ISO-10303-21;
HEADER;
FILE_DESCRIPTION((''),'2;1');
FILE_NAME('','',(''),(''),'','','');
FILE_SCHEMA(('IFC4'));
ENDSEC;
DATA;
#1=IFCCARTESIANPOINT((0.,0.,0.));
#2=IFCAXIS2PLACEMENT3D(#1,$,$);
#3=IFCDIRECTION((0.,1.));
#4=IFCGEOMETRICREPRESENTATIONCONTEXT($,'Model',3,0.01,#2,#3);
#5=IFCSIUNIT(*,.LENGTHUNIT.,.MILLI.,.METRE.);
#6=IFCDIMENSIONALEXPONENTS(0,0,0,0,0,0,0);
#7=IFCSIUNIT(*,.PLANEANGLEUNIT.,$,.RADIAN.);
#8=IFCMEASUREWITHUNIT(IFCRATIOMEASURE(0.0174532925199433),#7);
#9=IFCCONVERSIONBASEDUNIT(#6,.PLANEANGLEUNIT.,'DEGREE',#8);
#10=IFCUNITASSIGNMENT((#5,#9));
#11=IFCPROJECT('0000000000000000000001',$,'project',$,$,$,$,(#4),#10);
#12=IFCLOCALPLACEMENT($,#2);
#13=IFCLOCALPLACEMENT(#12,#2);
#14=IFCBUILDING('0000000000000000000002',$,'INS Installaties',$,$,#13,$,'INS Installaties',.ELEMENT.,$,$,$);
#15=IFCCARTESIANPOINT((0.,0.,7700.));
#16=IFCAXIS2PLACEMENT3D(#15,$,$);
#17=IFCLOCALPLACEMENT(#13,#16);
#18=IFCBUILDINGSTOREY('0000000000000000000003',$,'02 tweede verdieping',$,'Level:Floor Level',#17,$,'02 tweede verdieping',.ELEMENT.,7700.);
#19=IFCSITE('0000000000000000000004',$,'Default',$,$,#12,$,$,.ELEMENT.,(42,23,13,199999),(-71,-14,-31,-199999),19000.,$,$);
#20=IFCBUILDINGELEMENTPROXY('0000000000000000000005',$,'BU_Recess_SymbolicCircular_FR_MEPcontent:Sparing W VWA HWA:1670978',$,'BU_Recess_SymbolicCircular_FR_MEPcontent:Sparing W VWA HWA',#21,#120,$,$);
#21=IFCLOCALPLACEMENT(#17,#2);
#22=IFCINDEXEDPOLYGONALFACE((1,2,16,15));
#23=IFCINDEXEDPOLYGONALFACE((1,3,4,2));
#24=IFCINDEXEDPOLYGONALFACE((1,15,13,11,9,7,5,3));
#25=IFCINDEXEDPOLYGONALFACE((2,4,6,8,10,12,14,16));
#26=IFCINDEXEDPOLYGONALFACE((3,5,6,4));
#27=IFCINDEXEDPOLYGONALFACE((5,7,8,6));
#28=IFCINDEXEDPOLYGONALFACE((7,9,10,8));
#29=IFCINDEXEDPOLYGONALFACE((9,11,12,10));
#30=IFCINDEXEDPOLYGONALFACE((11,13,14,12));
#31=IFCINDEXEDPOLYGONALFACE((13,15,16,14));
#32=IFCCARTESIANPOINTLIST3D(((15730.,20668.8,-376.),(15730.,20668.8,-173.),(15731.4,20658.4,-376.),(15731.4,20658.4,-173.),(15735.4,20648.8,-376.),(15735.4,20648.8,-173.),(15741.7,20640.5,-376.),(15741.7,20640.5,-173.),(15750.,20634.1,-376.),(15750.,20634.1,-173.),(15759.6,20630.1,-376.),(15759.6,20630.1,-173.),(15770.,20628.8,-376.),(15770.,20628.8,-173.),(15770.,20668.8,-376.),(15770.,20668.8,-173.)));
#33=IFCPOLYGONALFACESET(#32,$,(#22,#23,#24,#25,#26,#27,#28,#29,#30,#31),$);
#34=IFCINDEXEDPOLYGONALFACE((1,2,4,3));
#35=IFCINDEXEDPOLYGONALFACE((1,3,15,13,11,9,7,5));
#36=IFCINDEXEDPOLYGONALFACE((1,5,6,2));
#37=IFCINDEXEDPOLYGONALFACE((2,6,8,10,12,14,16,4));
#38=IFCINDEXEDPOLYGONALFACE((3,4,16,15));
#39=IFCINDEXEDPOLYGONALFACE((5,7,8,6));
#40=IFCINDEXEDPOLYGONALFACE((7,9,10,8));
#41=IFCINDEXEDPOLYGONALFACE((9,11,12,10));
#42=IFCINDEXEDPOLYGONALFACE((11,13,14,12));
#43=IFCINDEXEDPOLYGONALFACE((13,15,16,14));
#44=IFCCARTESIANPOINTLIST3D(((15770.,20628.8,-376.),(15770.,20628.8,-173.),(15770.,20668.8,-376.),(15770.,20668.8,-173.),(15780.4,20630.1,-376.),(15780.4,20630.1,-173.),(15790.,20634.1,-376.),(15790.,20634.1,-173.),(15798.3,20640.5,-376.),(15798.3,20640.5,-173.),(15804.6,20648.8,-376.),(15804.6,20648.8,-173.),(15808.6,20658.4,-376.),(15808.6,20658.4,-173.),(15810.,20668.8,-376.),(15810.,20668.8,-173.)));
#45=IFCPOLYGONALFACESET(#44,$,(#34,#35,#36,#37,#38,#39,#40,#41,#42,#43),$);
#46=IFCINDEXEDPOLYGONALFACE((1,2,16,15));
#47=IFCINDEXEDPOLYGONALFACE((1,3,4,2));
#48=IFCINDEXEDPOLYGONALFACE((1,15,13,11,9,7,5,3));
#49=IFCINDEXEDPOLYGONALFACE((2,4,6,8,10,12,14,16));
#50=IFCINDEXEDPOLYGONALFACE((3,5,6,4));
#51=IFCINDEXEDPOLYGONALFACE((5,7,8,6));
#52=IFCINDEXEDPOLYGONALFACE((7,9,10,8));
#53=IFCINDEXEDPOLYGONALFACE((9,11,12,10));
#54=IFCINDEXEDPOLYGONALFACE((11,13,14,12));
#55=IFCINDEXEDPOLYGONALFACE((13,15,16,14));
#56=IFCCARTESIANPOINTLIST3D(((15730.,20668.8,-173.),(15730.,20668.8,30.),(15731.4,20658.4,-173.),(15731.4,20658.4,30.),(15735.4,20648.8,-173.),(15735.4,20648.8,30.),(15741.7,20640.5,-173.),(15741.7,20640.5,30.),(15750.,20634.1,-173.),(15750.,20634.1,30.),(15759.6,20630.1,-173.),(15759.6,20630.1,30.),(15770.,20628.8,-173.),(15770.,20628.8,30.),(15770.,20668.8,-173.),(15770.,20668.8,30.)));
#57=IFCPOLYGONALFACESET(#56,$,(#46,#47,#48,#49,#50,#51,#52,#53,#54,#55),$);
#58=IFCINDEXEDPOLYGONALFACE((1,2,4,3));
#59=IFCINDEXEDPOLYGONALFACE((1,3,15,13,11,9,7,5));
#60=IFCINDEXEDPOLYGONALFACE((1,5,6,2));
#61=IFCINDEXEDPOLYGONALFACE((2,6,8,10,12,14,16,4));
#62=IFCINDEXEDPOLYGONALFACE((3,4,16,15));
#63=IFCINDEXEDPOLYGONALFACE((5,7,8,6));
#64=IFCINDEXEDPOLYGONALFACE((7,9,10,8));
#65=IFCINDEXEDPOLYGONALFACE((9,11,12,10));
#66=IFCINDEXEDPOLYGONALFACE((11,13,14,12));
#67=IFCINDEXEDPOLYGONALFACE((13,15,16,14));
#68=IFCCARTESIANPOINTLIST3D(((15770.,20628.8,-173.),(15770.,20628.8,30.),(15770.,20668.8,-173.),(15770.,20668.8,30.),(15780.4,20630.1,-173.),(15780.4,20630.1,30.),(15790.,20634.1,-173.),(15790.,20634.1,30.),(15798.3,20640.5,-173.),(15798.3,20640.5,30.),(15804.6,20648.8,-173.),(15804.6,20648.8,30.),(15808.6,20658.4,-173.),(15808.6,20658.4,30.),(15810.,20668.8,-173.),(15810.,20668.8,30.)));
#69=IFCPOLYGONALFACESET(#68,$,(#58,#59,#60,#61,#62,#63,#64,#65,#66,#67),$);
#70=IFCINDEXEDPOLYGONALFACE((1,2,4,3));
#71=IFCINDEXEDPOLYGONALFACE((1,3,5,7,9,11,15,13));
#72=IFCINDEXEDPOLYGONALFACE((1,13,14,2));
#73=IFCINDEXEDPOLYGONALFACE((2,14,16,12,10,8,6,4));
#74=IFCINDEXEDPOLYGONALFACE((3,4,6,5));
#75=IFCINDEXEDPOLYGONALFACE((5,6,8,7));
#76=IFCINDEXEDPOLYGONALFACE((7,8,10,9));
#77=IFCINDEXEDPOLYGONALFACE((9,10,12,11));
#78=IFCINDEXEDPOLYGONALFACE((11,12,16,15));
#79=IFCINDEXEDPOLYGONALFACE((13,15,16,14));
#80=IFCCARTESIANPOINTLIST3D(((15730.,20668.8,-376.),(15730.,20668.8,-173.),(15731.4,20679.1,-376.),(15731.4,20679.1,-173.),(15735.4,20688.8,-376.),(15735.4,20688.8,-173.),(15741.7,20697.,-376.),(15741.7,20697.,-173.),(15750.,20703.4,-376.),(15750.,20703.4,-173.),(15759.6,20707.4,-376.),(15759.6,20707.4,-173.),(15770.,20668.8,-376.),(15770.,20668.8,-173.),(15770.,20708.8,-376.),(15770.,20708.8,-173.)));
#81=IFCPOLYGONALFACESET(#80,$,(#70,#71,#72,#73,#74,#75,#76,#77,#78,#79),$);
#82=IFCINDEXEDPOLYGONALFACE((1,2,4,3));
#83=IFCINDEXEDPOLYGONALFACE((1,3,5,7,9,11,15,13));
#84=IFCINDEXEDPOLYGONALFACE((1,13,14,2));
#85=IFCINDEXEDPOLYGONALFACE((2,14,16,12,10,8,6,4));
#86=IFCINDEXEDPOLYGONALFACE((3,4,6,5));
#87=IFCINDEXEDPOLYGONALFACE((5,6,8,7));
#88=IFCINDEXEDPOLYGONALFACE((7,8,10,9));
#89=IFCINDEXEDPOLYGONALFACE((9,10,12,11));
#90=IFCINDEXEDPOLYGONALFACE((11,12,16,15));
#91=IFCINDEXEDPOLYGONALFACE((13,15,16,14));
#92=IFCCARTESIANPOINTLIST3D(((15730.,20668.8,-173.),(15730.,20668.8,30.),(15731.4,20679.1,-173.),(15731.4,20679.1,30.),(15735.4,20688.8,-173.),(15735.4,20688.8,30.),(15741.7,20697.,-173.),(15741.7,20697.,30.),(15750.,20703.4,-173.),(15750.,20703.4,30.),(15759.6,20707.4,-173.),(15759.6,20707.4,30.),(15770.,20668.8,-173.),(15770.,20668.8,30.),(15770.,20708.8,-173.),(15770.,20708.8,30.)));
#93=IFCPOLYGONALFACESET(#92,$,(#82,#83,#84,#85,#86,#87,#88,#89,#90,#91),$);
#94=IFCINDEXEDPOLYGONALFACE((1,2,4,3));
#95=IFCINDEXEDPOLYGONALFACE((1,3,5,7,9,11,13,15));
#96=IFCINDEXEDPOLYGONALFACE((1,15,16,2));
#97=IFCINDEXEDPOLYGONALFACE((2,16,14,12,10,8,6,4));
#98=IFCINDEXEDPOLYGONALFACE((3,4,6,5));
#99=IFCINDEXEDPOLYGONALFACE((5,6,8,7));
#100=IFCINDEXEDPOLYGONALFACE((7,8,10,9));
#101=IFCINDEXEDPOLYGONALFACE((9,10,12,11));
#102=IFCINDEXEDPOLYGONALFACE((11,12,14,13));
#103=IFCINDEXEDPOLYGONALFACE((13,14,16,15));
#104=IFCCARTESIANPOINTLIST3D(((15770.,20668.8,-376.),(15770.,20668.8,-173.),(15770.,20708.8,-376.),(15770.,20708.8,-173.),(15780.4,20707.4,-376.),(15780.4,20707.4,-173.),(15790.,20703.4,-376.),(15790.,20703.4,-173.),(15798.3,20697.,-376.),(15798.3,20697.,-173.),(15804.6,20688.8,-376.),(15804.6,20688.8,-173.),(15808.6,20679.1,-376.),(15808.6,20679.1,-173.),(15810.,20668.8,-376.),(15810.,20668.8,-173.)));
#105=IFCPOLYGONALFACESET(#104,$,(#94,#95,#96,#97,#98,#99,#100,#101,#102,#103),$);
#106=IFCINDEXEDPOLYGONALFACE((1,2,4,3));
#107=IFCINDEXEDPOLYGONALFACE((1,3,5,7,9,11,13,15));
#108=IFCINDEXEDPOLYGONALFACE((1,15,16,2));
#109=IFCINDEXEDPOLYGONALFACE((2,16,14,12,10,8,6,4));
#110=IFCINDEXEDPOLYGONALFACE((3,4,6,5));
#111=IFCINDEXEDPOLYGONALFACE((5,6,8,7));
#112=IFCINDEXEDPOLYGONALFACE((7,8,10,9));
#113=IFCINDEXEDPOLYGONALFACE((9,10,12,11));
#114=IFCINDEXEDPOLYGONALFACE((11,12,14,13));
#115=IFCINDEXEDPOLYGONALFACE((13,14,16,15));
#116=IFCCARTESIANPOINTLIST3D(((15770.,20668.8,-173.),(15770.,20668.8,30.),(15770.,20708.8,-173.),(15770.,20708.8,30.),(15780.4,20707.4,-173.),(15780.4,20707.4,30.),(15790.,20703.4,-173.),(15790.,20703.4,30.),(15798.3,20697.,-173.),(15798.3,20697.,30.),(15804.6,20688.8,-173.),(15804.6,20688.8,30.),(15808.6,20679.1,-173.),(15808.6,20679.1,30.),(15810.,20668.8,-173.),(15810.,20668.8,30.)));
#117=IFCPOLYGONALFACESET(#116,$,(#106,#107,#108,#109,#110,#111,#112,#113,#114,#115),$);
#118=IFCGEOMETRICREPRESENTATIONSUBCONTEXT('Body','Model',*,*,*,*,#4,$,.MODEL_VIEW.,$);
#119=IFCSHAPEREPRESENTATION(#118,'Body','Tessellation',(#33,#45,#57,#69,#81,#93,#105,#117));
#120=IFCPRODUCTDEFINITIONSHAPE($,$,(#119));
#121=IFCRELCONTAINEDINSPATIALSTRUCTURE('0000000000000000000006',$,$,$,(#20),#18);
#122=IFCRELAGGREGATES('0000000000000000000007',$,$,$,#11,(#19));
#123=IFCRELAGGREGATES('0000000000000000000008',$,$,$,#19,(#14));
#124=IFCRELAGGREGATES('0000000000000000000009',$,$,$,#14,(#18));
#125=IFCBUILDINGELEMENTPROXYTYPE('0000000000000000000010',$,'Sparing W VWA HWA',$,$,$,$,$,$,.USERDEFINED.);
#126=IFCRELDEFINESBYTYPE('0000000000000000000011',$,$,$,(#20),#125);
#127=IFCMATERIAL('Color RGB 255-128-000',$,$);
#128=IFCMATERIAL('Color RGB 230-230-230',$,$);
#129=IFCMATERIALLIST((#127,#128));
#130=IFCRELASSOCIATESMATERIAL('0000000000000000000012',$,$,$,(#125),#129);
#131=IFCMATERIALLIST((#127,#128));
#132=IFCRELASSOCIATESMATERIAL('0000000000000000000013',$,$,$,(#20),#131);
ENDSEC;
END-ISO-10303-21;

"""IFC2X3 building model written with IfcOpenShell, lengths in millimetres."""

from ifc_helpers import new_model, entity, si_unit, converted_unit, direction, frame, frame_2d, origin, place, context, subcontext, project, spatial, polyline, circle_curve, parameter, trimmed, segment, composite_curve, outline, extrude, source, transform, mapped, material, material_list, type_object, type_shapes, element, save


model = new_model("IFC2X3")

# Units and contexts
model_context = context("Model", 3, precision=0.01, world=origin(), true_north=direction((0.0, 1.0)))
body_context = subcontext(model_context, "Body", "Model", "MODEL_VIEW")
ifc_project = project(units=[si_unit("LENGTHUNIT", "METRE", prefix="MILLI"), converted_unit("PLANEANGLEUNIT", "DEGREE", entity("IfcRatioMeasure", 0.0174532925199433), si_unit("PLANEANGLEUNIT", "RADIAN"), dimensions=[0, 0, 0, 0, 0, 0, 0])], contexts=[model_context])

# Site, building, storey
site_placement = place(None, origin())
site = spatial("IfcSite", under=ifc_project, at=site_placement, Name="Default", CompositionType="ELEMENT", RefLatitude=(42, 23, 13, 199999), RefLongitude=(-71, -14, -31, -199999), RefElevation=19000.0)
building_placement = place(site_placement, origin())
building = spatial("IfcBuilding", under=site, at=building_placement, Name="INS Installaties", LongName="INS Installaties", CompositionType="ELEMENT")
storey_placement = place(building_placement, frame((0.0, 0.0, 7700.0)))
storey = spatial("IfcBuildingStorey", under=building, at=storey_placement, Name="02 tweede verdieping", ObjectType="Level:Floor Level", LongName="02 tweede verdieping", CompositionType="ELEMENT", Elevation=7700.0)

# Building element proxy
ifc_material_1 = material(Name="Color RGB 255-128-000")
ifc_material_2 = material(Name="Color RGB 230-230-230")
ifc_material_list_1 = material_list([ifc_material_1, ifc_material_2])
building_element_proxy_type_1 = type_object("IfcBuildingElementProxyType", Name="Sparing W VWA HWA", PredefinedType="USERDEFINED", material=ifc_material_list_1)
shared_shape_1 = source(origin(), body_context, "Body", "SweptSolid", [
    extrude(outline(composite_curve([segment(trimmed(circle_curve(frame_2d((13.3, 13.3), x_axis=(1.0, 0.0)), 40.0), [parameter(180.0)], [parameter(270.0)], True, "PARAMETER"), True, "CONTINUOUS"), segment(polyline([(13.3, -26.7), (13.3, 13.3)]), True, "CONTINUOUS"), segment(polyline([(13.3, 13.3), (-26.7, 13.3)]), True, "CONTINUOUS")], self_intersect=False)), frame((13.3, 13.3, -403.0), z_axis=(0.0, 0.0, 1.0), x_axis=(-1.0, 0.0, 0.0)), (0.0, 0.0, 1.0), 203.0),
    extrude(outline(composite_curve([segment(polyline([(-26.7, -13.3), (13.3, -13.3)]), True, "CONTINUOUS"), segment(polyline([(13.3, -13.3), (13.3, 26.7)]), True, "CONTINUOUS"), segment(trimmed(circle_curve(frame_2d((13.3, -13.3), x_axis=(1.0, 0.0)), 40.0), [parameter(90.0)], [parameter(180.0)], True, "PARAMETER"), True, "CONTINUOUS")], self_intersect=False)), frame((-13.3, 13.3, -403.0)), (0.0, 0.0, 1.0), 203.0),
    extrude(outline(composite_curve([segment(trimmed(circle_curve(frame_2d((13.3, 13.3), x_axis=(1.0, 0.0)), 40.0), [parameter(180.0)], [parameter(270.0)], True, "PARAMETER"), True, "CONTINUOUS"), segment(polyline([(13.3, -26.7), (13.3, 13.3)]), True, "CONTINUOUS"), segment(polyline([(13.3, 13.3), (-26.7, 13.3)]), True, "CONTINUOUS")], self_intersect=False)), frame((13.3, 13.3, -200.0), z_axis=(0.0, 0.0, 1.0), x_axis=(-1.0, 0.0, 0.0)), (0.0, 0.0, 1.0), 203.0),
    extrude(outline(composite_curve([segment(polyline([(-26.7, -13.3), (13.3, -13.3)]), True, "CONTINUOUS"), segment(polyline([(13.3, -13.3), (13.3, 26.7)]), True, "CONTINUOUS"), segment(trimmed(circle_curve(frame_2d((13.3, -13.3), x_axis=(1.0, 0.0)), 40.0), [parameter(90.0)], [parameter(180.0)], True, "PARAMETER"), True, "CONTINUOUS")], self_intersect=False)), frame((-13.3, 13.3, -200.0)), (0.0, 0.0, 1.0), 203.0),
    extrude(outline(composite_curve([segment(polyline([(-26.7, -13.3), (13.3, -13.3)]), True, "CONTINUOUS"), segment(polyline([(13.3, -13.3), (13.3, 26.7)]), True, "CONTINUOUS"), segment(trimmed(circle_curve(frame_2d((13.3, -13.3), x_axis=(1.0, 0.0)), 40.0), [parameter(90.0)], [parameter(180.0)], True, "PARAMETER"), True, "CONTINUOUS")], self_intersect=False)), frame((13.3, -13.3, -403.0), z_axis=(0.0, 0.0, 1.0), x_axis=(-1.0, 0.0, 0.0)), (0.0, 0.0, 1.0), 203.0),
    extrude(outline(composite_curve([segment(polyline([(-26.7, -13.3), (13.3, -13.3)]), True, "CONTINUOUS"), segment(polyline([(13.3, -13.3), (13.3, 26.7)]), True, "CONTINUOUS"), segment(trimmed(circle_curve(frame_2d((13.3, -13.3), x_axis=(1.0, 0.0)), 40.0), [parameter(90.0)], [parameter(180.0)], True, "PARAMETER"), True, "CONTINUOUS")], self_intersect=False)), frame((13.3, -13.3, -200.0), z_axis=(0.0, 0.0, 1.0), x_axis=(-1.0, 0.0, 0.0)), (0.0, 0.0, 1.0), 203.0),
    extrude(outline(composite_curve([segment(trimmed(circle_curve(frame_2d((13.3, 13.3), x_axis=(1.0, 0.0)), 40.0), [parameter(180.0)], [parameter(270.0)], True, "PARAMETER"), True, "CONTINUOUS"), segment(polyline([(13.3, -26.7), (13.3, 13.3)]), True, "CONTINUOUS"), segment(polyline([(13.3, 13.3), (-26.7, 13.3)]), True, "CONTINUOUS")], self_intersect=False)), frame((-13.3, -13.3, -403.0)), (0.0, 0.0, 1.0), 203.0),
    extrude(outline(composite_curve([segment(trimmed(circle_curve(frame_2d((13.3, 13.3), x_axis=(1.0, 0.0)), 40.0), [parameter(180.0)], [parameter(270.0)], True, "PARAMETER"), True, "CONTINUOUS"), segment(polyline([(13.3, -26.7), (13.3, 13.3)]), True, "CONTINUOUS"), segment(polyline([(13.3, 13.3), (-26.7, 13.3)]), True, "CONTINUOUS")], self_intersect=False)), frame((-13.3, -13.3, -200.0)), (0.0, 0.0, 1.0), 203.0),
])
type_shapes(building_element_proxy_type_1, [shared_shape_1])
ifc_material_list_2 = material_list([ifc_material_1, ifc_material_2])
proxy_1_placement = place(storey_placement, frame((15770.0, 20668.8, 27.0), z_axis=(0.0, 0.0, 1.0), x_axis=(-1.0, 0.0, 0.0)))
element("IfcBuildingElementProxy", 1, at=proxy_1_placement, inside=storey, type_object=building_element_proxy_type_1, material=ifc_material_list_2, Name="BU_Recess_SymbolicCircular_FR_MEPcontent:Sparing W VWA HWA:1670978", ObjectType="BU_Recess_SymbolicCircular_FR_MEPcontent:Sparing W VWA HWA", context=body_context, shape_type="MappedRepresentation", body=[
    mapped(shared_shape_1, transform((0.0, 0.0, 0.0), scale=1.0)),
])

save(model, "model.ifc")
